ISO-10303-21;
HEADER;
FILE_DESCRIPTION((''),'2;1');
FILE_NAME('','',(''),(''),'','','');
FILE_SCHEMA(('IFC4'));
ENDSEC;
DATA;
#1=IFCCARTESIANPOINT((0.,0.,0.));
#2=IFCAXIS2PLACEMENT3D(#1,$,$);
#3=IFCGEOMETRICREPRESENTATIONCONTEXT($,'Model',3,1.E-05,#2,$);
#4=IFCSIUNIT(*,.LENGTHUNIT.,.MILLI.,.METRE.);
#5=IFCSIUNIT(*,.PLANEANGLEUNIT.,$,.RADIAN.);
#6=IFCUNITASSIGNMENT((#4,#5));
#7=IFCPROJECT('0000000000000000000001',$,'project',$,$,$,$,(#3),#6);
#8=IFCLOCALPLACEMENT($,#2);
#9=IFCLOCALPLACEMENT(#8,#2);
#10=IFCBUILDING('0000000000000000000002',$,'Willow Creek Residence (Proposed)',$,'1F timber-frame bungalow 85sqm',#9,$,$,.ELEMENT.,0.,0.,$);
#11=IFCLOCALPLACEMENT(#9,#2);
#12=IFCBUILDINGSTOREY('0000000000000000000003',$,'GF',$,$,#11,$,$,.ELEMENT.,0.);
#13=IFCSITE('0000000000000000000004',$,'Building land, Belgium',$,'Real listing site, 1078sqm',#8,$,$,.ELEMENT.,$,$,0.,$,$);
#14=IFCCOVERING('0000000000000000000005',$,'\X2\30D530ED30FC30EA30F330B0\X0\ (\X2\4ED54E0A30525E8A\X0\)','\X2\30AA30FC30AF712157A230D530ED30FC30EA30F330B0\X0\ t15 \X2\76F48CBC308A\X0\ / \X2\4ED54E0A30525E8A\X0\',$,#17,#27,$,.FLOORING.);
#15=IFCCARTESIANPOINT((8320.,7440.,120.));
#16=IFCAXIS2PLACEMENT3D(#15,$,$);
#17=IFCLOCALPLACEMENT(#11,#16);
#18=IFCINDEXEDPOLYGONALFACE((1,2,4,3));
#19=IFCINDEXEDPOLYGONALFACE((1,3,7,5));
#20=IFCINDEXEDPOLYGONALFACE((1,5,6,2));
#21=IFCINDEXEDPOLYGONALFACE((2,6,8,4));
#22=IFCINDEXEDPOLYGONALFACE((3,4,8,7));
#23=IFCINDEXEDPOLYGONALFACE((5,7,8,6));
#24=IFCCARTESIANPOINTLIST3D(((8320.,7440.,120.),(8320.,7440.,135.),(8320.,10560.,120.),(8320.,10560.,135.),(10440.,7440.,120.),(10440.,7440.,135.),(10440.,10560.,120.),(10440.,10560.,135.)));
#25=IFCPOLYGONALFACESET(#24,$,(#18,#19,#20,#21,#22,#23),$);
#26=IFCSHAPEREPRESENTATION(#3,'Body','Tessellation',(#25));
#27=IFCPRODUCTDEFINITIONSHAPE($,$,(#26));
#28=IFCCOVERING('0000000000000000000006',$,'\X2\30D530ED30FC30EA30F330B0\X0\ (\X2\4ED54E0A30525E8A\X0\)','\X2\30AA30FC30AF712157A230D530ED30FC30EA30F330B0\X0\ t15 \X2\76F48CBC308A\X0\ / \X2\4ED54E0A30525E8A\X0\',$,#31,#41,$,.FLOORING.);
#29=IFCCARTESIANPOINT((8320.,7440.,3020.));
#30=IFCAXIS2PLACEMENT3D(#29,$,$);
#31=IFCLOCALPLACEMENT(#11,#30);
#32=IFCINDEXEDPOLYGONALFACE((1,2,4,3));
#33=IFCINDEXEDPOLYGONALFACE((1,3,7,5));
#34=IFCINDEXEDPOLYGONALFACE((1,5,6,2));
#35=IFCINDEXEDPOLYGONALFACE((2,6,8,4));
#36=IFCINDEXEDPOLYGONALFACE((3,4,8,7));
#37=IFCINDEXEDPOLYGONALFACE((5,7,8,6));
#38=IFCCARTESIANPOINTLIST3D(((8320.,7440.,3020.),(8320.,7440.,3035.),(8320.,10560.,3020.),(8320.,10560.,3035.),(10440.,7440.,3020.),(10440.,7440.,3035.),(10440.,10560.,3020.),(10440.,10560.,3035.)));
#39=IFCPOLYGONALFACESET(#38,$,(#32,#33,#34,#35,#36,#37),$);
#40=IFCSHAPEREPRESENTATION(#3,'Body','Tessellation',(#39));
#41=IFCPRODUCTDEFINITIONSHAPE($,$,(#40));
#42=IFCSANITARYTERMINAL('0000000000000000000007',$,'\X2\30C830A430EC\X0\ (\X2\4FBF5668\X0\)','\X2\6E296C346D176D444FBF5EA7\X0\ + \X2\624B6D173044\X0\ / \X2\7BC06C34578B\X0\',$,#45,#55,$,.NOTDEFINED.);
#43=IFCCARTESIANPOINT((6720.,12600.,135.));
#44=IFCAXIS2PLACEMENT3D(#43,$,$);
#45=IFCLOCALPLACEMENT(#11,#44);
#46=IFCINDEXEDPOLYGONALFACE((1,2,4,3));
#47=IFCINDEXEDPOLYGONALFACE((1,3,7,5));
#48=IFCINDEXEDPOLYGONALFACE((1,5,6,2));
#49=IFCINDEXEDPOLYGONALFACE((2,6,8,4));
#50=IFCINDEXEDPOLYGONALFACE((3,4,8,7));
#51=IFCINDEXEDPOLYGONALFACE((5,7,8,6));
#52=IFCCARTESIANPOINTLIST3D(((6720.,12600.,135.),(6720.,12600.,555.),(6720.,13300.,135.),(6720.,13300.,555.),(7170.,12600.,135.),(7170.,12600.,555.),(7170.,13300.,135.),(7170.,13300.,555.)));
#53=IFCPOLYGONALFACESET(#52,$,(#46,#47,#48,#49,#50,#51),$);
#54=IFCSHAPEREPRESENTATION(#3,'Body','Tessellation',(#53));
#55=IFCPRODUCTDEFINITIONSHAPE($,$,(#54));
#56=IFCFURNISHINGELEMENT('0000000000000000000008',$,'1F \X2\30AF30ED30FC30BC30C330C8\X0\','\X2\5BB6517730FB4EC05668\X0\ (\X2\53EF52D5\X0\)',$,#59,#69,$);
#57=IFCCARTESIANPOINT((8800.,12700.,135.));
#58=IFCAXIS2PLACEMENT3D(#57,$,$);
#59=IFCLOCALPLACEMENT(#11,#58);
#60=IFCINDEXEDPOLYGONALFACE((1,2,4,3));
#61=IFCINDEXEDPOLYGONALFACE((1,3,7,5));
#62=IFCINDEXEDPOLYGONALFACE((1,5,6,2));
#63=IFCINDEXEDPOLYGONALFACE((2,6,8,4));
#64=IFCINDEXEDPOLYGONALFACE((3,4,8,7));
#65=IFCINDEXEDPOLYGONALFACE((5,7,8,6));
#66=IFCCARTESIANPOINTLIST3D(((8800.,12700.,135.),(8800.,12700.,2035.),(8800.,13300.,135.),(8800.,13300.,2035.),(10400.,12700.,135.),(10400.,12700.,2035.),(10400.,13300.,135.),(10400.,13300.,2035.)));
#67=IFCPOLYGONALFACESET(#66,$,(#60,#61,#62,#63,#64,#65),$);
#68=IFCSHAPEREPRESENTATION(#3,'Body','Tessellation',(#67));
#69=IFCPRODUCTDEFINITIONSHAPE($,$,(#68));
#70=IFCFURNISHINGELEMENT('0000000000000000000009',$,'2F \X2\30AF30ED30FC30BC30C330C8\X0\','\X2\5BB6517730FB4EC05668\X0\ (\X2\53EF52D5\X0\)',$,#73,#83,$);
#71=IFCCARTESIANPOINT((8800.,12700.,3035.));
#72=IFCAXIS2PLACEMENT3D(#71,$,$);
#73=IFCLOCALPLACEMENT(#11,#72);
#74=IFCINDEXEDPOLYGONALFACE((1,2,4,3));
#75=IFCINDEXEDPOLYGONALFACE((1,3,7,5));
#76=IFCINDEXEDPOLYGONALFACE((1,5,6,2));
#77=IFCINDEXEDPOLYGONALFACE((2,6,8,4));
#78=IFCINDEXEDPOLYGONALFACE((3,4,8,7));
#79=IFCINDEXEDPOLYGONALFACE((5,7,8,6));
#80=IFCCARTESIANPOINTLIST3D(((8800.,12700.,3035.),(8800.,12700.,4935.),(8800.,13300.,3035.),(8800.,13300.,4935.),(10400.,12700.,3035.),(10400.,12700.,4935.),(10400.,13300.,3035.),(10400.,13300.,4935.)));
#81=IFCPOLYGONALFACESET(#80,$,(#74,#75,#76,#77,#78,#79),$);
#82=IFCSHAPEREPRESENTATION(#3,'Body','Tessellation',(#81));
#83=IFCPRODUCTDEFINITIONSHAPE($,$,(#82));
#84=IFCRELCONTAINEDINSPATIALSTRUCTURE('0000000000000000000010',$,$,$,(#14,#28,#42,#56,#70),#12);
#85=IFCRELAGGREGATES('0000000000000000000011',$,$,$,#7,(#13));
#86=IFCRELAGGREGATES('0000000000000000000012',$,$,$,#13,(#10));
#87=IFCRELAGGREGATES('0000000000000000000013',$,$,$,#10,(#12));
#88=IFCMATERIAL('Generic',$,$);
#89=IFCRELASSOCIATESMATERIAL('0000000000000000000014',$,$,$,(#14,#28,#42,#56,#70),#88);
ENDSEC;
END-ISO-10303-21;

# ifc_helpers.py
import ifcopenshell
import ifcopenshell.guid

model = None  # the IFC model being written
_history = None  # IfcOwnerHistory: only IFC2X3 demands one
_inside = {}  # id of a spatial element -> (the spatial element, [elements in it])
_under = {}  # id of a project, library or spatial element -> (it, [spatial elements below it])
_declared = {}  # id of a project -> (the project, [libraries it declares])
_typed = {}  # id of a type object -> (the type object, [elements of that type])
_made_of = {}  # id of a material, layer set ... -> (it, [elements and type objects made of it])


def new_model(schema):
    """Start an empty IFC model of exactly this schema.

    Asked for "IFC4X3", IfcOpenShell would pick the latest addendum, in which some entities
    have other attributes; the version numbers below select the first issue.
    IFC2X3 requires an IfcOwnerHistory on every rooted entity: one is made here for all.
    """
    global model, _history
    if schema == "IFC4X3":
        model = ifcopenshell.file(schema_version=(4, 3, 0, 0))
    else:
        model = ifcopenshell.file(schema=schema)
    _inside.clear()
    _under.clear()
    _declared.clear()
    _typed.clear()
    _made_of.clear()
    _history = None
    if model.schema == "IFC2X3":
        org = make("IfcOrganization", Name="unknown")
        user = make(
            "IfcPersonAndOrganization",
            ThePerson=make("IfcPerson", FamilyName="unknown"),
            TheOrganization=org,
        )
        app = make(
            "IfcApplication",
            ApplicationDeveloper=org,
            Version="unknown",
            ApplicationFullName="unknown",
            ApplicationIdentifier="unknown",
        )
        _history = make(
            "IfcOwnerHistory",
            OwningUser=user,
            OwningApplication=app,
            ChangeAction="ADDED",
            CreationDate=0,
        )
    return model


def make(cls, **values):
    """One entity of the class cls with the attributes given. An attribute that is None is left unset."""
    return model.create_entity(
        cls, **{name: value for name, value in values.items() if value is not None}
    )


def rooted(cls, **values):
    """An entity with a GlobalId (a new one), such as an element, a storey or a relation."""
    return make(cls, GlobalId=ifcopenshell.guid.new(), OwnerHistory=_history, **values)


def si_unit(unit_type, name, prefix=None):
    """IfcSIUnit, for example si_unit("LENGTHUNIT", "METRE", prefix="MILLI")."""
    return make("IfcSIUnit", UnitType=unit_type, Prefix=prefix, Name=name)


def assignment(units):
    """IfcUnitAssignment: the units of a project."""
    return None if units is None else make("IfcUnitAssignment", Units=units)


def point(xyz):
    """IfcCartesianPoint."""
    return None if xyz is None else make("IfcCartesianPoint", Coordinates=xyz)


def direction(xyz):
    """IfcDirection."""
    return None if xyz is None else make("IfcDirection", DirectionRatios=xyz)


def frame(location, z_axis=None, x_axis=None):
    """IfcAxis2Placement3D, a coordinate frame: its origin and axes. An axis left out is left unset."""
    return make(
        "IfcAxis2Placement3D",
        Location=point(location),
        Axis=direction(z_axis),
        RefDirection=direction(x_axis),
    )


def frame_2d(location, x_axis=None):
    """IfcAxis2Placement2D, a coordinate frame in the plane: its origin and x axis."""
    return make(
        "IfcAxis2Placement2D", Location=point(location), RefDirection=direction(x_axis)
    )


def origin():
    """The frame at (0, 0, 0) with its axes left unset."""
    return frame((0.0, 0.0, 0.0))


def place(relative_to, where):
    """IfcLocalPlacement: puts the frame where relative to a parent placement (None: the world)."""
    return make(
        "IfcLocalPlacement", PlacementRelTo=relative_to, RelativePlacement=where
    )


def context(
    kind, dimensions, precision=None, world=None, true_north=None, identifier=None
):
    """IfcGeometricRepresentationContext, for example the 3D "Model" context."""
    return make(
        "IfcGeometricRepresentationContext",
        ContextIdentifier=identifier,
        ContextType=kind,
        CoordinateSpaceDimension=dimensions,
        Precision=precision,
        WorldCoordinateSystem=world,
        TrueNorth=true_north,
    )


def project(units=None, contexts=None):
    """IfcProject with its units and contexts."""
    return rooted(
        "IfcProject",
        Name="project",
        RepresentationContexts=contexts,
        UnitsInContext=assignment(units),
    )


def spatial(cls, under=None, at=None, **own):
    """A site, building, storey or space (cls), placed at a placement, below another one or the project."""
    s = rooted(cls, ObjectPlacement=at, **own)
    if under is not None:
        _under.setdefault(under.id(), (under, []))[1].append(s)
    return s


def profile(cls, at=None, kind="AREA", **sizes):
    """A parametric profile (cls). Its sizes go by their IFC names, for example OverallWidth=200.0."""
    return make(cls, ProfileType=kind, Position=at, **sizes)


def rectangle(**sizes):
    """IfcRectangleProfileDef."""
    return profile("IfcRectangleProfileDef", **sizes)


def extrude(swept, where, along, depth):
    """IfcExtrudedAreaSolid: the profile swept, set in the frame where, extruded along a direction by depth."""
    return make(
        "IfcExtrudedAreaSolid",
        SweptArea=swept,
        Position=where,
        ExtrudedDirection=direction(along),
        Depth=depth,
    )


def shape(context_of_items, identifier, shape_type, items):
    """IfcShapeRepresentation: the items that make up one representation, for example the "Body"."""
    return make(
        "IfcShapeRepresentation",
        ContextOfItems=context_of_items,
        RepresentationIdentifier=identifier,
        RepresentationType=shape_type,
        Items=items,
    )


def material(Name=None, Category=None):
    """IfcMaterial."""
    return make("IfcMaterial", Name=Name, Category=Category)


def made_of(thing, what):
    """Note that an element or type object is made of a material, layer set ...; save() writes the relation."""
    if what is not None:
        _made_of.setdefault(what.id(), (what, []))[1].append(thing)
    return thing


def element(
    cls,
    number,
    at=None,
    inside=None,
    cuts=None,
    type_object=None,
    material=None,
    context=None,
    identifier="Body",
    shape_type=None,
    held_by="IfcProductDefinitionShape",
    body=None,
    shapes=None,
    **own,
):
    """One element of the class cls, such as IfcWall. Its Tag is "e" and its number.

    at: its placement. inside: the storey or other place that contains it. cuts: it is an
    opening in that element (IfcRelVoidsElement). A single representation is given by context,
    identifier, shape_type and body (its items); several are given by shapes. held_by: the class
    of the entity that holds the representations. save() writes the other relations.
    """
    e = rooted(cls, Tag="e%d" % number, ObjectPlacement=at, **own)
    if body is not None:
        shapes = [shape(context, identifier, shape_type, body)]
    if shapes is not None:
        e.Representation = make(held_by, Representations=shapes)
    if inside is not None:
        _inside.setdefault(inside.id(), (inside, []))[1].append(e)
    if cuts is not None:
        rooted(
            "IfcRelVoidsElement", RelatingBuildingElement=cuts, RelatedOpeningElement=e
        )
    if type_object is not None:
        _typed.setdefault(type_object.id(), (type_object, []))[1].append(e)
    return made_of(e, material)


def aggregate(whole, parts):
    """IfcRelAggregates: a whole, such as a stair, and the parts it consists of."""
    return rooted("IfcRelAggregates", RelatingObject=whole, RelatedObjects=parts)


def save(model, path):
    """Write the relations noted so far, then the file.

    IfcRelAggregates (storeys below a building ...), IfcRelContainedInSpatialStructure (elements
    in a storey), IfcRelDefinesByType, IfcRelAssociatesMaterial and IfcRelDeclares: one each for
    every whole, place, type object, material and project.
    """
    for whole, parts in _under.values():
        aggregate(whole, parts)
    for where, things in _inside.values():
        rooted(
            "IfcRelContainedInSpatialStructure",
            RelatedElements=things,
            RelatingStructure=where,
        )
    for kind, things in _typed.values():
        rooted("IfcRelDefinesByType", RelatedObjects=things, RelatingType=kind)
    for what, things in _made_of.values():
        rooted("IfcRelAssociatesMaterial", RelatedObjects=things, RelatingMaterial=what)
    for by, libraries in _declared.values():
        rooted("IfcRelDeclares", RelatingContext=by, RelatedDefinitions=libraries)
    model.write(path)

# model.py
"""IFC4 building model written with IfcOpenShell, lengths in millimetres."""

from ifc_helpers import new_model, si_unit, frame, frame_2d, origin, place, context, project, spatial, rectangle, extrude, material, element, save


model = new_model("IFC4")

# Units and contexts
model_context = context("Model", 3, precision=1e-05, world=origin())
ifc_project = project(units=[si_unit("LENGTHUNIT", "METRE", prefix="MILLI"), si_unit("PLANEANGLEUNIT", "RADIAN")], contexts=[model_context])

# Site, building, storey
site_placement = place(None, origin())
site = spatial("IfcSite", under=ifc_project, at=site_placement, Name="Building land, Belgium", ObjectType="Real listing site, 1078sqm", CompositionType="ELEMENT", RefElevation=0.0)
building_placement = place(site_placement, origin())
building = spatial("IfcBuilding", under=site, at=building_placement, Name="Willow Creek Residence (Proposed)", ObjectType="1F timber-frame bungalow 85sqm", CompositionType="ELEMENT", ElevationOfRefHeight=0.0, ElevationOfTerrain=0.0)
storey_placement = place(building_placement, origin())
storey = spatial("IfcBuildingStorey", under=building, at=storey_placement, Name="GF", CompositionType="ELEMENT", Elevation=0.0)

# Shared definitions
ifc_material_1 = material(Name="Generic")

# Coverings
covering_1_placement = place(storey_placement, frame((8320.0, 7440.0, 120.0)))
element("IfcCovering", 1, at=covering_1_placement, inside=storey, material=ifc_material_1, Name="フローリング (仕上げ床)", Description="オーク無垢フローリング t15 直貼り / 仕上げ床", PredefinedType="FLOORING", context=model_context, shape_type="SweptSolid", body=[
    extrude(rectangle(XDim=2120.0, YDim=3120.0, at=frame_2d((1060.0, 1560.0))), frame((8320.0, 7440.0, 120.0)), (0.0, 0.0, 1.0), 15.0),
])
covering_2_placement = place(storey_placement, frame((8320.0, 7440.0, 3020.0)))
element("IfcCovering", 2, at=covering_2_placement, inside=storey, material=ifc_material_1, Name="フローリング (仕上げ床)", Description="オーク無垢フローリング t15 直貼り / 仕上げ床", PredefinedType="FLOORING", context=model_context, shape_type="SweptSolid", body=[
    extrude(rectangle(XDim=2120.0, YDim=3120.0, at=frame_2d((1060.0, 1560.0))), frame((8320.0, 7440.0, 3020.0)), (0.0, 0.0, 1.0), 15.0),
])

# Sanitary terminal
sanitary_terminal_placement = place(storey_placement, frame((6720.0, 12600.0, 135.0)))
element("IfcSanitaryTerminal", 3, at=sanitary_terminal_placement, inside=storey, material=ifc_material_1, Name="トイレ (便器)", Description="温水洗浄便座 + 手洗い / 節水型", PredefinedType="NOTDEFINED", context=model_context, shape_type="SweptSolid", body=[
    extrude(rectangle(XDim=450.0, YDim=700.0, at=frame_2d((225.0, 350.0))), frame((6720.0, 12600.0, 135.0)), (0.0, 0.0, 1.0), 420.0),
])

# Furnishing elements
furnishing_1_placement = place(storey_placement, frame((8800.0, 12700.0, 135.0)))
element("IfcFurnishingElement", 4, at=furnishing_1_placement, inside=storey, material=ifc_material_1, Name="1F クローゼット", Description="家具・什器 (可動)", context=model_context, shape_type="SweptSolid", body=[
    extrude(rectangle(XDim=1600.0, YDim=600.0, at=frame_2d((800.0, 300.0))), frame((8800.0, 12700.0, 135.0)), (0.0, 0.0, 1.0), 1900.0),
])
furnishing_2_placement = place(storey_placement, frame((8800.0, 12700.0, 3035.0)))
element("IfcFurnishingElement", 5, at=furnishing_2_placement, inside=storey, material=ifc_material_1, Name="2F クローゼット", Description="家具・什器 (可動)", context=model_context, shape_type="SweptSolid", body=[
    extrude(rectangle(XDim=1600.0, YDim=600.0, at=frame_2d((800.0, 300.0))), frame((8800.0, 12700.0, 3035.0)), (0.0, 0.0, 1.0), 1900.0),
])

save(model, "model.ifc")
